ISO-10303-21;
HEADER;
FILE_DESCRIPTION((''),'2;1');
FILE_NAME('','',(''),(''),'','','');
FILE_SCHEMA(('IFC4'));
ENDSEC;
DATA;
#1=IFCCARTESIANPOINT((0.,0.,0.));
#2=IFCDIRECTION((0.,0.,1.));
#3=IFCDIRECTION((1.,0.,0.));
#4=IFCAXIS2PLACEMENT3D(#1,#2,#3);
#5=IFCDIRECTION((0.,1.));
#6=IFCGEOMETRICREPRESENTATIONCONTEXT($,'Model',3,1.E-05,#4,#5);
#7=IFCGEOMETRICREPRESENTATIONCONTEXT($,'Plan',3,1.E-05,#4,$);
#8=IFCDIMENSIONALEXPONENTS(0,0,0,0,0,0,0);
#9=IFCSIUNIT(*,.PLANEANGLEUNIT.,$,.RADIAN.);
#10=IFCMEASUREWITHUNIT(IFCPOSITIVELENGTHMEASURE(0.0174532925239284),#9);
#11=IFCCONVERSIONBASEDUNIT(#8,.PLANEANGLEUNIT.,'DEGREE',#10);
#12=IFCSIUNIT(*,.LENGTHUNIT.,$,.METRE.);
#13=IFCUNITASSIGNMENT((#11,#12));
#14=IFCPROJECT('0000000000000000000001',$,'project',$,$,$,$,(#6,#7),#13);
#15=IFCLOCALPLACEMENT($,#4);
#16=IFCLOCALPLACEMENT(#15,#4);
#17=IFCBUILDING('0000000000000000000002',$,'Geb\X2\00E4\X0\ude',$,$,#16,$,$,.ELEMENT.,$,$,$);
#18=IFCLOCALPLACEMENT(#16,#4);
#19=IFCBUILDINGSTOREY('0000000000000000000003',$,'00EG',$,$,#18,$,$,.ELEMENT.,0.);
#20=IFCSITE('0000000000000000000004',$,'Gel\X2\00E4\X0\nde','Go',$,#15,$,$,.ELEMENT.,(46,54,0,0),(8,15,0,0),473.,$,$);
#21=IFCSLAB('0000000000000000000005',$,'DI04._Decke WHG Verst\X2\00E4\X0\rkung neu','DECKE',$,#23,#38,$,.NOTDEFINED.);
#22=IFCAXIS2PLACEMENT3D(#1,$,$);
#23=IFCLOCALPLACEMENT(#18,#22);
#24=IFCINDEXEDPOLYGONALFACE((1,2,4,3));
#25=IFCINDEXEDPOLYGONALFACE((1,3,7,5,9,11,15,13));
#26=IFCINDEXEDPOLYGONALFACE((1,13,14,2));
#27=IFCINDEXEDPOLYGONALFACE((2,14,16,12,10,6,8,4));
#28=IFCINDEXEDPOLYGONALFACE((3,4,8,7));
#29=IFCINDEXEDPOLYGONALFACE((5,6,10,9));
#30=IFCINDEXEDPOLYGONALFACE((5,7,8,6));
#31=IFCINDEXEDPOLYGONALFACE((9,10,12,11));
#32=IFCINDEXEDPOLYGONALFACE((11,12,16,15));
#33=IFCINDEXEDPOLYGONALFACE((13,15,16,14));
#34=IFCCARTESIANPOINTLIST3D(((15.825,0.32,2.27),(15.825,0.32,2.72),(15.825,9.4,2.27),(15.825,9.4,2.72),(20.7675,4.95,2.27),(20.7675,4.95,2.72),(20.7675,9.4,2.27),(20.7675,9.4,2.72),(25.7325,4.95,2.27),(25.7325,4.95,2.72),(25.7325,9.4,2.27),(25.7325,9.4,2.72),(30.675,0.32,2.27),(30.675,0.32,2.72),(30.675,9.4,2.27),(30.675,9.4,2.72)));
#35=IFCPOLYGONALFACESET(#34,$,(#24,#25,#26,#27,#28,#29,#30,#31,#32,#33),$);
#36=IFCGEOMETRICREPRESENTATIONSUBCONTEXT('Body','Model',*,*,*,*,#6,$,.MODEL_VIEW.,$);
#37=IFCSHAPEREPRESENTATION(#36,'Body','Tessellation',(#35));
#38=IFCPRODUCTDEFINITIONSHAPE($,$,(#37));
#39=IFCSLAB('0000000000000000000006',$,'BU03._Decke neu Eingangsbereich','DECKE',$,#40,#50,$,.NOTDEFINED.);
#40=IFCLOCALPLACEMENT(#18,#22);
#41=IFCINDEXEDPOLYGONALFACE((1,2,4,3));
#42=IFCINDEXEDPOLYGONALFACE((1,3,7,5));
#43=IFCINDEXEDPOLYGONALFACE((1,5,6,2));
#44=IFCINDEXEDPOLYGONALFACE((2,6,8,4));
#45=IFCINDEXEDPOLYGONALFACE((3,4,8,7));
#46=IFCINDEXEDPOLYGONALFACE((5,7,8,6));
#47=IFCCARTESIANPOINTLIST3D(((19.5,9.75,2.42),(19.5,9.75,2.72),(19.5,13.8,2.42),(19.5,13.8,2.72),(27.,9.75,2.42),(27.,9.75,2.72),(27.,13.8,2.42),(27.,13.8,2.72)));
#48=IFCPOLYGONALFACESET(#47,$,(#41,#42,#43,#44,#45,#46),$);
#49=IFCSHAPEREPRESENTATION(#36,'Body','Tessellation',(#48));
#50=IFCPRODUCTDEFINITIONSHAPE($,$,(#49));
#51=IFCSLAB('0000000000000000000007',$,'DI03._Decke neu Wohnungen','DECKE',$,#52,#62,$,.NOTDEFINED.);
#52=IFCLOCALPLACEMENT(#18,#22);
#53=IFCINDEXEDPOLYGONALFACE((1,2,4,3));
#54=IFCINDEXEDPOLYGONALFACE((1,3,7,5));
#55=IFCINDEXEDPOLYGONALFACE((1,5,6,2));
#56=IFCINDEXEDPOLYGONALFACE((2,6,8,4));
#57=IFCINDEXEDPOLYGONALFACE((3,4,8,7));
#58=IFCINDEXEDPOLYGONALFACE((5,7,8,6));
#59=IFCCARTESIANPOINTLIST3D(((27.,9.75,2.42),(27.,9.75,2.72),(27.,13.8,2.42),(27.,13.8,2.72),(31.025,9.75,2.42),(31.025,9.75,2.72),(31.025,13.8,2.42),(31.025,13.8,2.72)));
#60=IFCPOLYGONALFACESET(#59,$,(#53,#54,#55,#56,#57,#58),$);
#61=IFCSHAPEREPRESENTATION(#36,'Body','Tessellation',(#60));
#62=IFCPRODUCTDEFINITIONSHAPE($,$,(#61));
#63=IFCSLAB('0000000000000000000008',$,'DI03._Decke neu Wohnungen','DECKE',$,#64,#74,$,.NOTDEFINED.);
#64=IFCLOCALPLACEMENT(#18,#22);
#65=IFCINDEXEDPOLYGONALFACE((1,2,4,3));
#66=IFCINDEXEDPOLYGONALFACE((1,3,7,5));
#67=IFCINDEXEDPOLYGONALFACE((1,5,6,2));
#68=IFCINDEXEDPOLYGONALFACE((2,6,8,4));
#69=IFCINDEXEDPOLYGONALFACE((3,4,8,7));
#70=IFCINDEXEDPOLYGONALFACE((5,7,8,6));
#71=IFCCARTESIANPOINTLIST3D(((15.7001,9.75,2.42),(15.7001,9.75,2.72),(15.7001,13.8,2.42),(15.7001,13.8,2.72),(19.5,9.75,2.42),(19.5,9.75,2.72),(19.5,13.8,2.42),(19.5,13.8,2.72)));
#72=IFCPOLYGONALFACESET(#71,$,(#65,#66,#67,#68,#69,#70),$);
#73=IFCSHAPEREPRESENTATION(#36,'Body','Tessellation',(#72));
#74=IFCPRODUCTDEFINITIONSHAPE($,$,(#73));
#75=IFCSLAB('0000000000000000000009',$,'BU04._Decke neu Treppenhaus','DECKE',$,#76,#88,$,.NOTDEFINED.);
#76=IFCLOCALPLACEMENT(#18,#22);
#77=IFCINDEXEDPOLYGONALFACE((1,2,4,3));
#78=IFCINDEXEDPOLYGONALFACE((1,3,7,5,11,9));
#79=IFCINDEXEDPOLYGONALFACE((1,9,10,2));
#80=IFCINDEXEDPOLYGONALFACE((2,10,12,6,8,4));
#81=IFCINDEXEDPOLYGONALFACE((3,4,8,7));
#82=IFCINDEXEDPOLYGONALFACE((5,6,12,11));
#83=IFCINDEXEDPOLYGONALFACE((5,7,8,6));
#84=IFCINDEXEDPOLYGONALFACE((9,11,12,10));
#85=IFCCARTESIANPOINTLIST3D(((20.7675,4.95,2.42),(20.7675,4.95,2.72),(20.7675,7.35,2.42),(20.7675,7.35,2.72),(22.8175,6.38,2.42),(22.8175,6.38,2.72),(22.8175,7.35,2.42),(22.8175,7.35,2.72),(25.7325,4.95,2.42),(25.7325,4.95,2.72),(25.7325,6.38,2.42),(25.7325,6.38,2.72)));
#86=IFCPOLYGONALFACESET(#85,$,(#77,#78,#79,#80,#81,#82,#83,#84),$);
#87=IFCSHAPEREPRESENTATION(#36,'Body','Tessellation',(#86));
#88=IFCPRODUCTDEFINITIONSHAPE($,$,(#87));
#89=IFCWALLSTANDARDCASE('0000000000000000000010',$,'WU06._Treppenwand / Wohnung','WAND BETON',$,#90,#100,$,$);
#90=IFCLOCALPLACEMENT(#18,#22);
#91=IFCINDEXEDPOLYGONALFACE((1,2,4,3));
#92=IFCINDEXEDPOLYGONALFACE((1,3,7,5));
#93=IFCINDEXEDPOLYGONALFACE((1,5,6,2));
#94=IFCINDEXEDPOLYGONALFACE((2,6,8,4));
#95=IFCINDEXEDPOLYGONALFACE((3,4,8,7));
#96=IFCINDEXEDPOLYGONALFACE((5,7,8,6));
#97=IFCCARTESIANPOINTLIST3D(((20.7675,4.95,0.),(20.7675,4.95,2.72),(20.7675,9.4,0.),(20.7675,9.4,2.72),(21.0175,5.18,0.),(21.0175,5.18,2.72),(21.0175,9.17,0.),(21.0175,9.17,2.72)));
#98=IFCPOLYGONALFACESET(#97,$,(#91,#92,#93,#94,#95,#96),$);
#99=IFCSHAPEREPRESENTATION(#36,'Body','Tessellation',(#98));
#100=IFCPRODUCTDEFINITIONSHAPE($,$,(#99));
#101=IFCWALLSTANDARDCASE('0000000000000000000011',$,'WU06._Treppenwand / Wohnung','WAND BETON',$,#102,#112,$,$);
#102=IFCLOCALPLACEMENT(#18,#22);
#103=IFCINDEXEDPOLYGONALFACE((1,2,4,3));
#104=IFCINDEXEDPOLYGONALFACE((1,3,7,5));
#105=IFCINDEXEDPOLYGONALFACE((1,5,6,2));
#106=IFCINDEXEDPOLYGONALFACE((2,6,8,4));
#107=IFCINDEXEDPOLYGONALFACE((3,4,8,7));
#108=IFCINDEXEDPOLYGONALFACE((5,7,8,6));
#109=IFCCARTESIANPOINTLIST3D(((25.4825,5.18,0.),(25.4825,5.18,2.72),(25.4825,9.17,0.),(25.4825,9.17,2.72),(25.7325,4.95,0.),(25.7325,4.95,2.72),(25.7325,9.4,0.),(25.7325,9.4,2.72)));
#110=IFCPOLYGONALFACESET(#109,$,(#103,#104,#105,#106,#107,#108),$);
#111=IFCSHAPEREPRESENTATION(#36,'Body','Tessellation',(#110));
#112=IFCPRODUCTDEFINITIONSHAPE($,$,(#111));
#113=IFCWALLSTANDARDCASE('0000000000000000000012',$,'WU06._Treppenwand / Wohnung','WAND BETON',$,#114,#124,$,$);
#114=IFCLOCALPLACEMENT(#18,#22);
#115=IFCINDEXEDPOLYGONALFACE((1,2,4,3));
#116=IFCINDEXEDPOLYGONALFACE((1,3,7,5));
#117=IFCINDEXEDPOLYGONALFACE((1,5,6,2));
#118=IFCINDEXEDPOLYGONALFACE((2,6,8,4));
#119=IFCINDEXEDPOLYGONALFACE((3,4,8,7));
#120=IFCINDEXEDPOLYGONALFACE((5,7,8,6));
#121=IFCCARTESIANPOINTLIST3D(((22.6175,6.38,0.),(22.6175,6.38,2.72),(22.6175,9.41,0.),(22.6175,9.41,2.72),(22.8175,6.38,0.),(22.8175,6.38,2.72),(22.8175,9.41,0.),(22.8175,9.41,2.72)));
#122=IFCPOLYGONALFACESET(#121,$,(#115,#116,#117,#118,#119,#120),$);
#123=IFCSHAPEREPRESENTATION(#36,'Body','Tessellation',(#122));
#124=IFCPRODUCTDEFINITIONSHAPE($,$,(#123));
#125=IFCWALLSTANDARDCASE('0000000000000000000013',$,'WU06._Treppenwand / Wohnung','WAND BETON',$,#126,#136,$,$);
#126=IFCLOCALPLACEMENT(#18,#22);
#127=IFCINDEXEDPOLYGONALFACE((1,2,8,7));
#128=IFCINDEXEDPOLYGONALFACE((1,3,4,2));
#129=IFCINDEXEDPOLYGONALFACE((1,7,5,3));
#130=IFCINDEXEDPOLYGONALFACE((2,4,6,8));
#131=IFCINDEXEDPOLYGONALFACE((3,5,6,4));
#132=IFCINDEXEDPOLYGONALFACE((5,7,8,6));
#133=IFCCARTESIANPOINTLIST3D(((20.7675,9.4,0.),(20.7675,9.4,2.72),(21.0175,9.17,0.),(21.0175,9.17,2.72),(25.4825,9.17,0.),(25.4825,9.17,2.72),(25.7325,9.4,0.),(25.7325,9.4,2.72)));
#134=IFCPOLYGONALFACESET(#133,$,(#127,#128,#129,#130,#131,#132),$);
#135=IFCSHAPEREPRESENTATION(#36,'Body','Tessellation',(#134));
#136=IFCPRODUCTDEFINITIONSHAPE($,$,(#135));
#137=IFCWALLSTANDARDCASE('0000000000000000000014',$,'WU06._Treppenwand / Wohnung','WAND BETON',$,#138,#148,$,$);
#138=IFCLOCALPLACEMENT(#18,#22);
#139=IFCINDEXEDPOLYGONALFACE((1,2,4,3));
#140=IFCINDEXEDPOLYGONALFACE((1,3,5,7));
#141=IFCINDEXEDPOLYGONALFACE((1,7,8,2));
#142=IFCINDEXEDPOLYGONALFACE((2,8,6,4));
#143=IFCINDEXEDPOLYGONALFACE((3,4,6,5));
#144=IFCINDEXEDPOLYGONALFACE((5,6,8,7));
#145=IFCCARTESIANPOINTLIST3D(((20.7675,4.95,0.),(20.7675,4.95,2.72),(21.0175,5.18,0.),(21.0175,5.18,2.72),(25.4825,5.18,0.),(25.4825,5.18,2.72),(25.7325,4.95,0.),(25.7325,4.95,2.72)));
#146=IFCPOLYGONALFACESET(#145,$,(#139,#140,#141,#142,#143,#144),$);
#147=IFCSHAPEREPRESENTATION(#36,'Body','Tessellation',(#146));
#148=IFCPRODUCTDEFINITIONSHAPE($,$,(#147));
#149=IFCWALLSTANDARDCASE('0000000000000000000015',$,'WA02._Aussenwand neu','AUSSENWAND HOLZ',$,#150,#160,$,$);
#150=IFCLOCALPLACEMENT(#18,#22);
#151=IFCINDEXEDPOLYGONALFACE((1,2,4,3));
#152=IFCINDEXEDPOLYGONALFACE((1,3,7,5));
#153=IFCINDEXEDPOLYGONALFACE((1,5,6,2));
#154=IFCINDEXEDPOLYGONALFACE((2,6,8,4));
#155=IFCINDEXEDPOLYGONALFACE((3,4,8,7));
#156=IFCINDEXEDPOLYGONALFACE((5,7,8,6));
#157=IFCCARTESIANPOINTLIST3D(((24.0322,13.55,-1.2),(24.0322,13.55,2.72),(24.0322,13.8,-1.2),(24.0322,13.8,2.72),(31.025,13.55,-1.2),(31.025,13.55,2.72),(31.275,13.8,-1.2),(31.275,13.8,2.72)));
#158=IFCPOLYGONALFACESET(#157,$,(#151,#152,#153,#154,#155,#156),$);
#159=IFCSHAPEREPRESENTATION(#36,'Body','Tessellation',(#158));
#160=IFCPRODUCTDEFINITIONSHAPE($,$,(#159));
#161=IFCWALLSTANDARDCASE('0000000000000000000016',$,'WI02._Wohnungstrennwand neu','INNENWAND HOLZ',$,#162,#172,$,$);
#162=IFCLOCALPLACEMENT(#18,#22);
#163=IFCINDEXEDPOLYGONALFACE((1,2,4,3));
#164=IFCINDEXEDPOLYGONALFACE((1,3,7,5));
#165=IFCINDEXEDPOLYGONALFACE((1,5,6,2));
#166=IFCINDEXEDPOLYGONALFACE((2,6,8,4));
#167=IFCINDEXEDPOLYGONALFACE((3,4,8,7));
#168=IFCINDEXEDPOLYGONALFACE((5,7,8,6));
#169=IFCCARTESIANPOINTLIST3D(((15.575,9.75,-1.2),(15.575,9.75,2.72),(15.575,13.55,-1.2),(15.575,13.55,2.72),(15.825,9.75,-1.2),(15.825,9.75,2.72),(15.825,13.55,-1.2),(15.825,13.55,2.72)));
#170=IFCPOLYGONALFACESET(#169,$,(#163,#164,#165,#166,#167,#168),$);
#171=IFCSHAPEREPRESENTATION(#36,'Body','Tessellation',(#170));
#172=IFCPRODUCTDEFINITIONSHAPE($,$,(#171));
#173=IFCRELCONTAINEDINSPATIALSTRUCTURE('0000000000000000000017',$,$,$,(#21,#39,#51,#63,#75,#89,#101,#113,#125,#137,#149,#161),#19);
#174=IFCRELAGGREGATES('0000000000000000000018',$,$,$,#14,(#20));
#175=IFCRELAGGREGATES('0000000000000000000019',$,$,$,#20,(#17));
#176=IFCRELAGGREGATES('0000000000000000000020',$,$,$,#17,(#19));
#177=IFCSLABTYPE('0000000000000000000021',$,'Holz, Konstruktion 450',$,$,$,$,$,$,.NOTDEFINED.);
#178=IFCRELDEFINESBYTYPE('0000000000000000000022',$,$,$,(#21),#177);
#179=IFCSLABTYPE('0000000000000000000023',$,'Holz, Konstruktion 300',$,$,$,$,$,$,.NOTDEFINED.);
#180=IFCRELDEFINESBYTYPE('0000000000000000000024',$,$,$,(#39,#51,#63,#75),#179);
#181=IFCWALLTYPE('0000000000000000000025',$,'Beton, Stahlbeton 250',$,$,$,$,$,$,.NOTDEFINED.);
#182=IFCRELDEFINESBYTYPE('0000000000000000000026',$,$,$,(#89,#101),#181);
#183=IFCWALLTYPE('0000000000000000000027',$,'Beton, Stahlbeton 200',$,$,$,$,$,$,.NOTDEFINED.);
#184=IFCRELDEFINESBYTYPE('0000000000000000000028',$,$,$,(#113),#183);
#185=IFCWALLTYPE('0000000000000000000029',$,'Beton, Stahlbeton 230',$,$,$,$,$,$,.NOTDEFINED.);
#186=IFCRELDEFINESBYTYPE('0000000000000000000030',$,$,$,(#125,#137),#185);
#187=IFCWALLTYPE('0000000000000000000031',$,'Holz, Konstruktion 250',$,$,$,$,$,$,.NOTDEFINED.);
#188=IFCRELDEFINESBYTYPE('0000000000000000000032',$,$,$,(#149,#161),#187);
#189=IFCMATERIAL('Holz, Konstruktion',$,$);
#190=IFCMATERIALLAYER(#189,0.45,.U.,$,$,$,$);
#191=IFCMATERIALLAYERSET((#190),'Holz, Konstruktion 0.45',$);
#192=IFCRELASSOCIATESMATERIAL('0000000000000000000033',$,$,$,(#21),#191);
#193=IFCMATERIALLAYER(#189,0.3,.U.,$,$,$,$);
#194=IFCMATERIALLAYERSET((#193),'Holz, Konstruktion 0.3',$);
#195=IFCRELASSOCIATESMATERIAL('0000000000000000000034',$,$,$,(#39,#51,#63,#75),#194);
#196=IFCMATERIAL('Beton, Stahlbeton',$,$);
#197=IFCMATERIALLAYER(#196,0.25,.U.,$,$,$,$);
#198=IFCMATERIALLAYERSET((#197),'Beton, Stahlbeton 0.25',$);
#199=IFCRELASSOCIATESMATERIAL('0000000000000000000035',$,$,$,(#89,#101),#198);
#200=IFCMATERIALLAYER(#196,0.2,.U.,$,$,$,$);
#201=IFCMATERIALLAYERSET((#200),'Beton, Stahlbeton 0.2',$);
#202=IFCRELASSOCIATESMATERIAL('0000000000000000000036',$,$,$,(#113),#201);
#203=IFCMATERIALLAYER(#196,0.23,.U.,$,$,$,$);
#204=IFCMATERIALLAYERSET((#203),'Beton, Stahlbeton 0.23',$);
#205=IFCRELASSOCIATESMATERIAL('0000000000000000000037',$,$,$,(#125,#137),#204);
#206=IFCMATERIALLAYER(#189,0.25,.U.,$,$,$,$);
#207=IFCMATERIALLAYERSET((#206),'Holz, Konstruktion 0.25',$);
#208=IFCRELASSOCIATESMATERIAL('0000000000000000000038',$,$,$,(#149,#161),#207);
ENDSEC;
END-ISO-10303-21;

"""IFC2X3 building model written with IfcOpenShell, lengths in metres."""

from ifc_helpers import new_model, entity, si_unit, converted_unit, direction, frame, origin_with_axes, place, context, subcontext, project, spatial, polyline, outline, extrude, material, layer, layer_set, layer_usage, type_object, element, save


model = new_model("IFC2X3")

# Units and contexts
model_context = context("Model", 3, precision=1e-05, world=origin_with_axes(), true_north=direction((0.0, 1.0)))
plan_context = context("Plan", 3, precision=1e-05, world=origin_with_axes())
body_context = subcontext(model_context, "Body", "Model", "MODEL_VIEW")
ifc_project = project(units=[converted_unit("PLANEANGLEUNIT", "DEGREE", entity("IfcPositiveLengthMeasure", 0.0174532925239284), si_unit("PLANEANGLEUNIT", "RADIAN"), dimensions=[0, 0, 0, 0, 0, 0, 0]), si_unit("LENGTHUNIT", "METRE")], contexts=[model_context, plan_context])

# Site, building, storey
site_placement = place(None, origin_with_axes())
site = spatial("IfcSite", under=ifc_project, at=site_placement, Name="Gelände", Description="Go", CompositionType="ELEMENT", RefLatitude=(46, 54, 0, 0), RefLongitude=(8, 15, 0, 0), RefElevation=473.0)
building_placement = place(site_placement, origin_with_axes())
building = spatial("IfcBuilding", under=site, at=building_placement, Name="Gebäude", CompositionType="ELEMENT")
storey_placement = place(building_placement, origin_with_axes())
storey = spatial("IfcBuildingStorey", under=building, at=storey_placement, Name="00EG", CompositionType="ELEMENT", Elevation=0.0)

# Slabs
ifc_material_1 = material(Name="Holz, Konstruktion")
ifc_layer_1 = layer(ifc_material_1, 0.45, ventilated="UNKNOWN")
ifc_layer_set_1 = layer_set([ifc_layer_1], Name="Holz, Konstruktion 0.45")
ifc_layer_usage_1 = layer_usage(ifc_layer_set_1, "AXIS3", "NEGATIVE", 0.45)
slab_type_1 = type_object("IfcSlabType", Name="Holz, Konstruktion 450", PredefinedType="NOTDEFINED")
slab_1_placement = place(storey_placement, frame((15.825, 9.4, 2.72), z_axis=(0.0, 0.0, 1.0), x_axis=(1.0, 0.0, 0.0)))
element("IfcSlab", 1, at=slab_1_placement, inside=storey, type_object=slab_type_1, material=ifc_layer_usage_1, Name="DI04._Decke WHG Verstärkung neu", Description="DECKE", PredefinedType="NOTDEFINED", context=body_context, shape_type="SweptSolid", body=[
    extrude(outline(polyline([(0.0, 0.0), (0.0, -9.08), (14.85, -9.08), (14.85, 0.0), (9.9075, 0.0), (9.9075, -4.45), (4.9425, -4.45), (4.9425, 0.0), (0.0, 0.0)])), frame((0.0, 0.0, -0.45), z_axis=(0.0, 0.0, 1.0), x_axis=(1.0, 0.0, 0.0)), (0.0, 0.0, 1.0), 0.45),
])
ifc_layer_2 = layer(ifc_material_1, 0.3, ventilated="UNKNOWN")
ifc_layer_set_2 = layer_set([ifc_layer_2], Name="Holz, Konstruktion 0.3")
ifc_layer_usage_2 = layer_usage(ifc_layer_set_2, "AXIS3", "NEGATIVE", 0.3)
slab_type_2 = type_object("IfcSlabType", Name="Holz, Konstruktion 300", PredefinedType="NOTDEFINED")
slab_2_placement = place(storey_placement, frame((19.5, 9.75, 2.72), z_axis=(0.0, 0.0, 1.0), x_axis=(1.0, 0.0, 0.0)))
element("IfcSlab", 2, at=slab_2_placement, inside=storey, type_object=slab_type_2, material=ifc_layer_usage_2, Name="BU03._Decke neu Eingangsbereich", Description="DECKE", PredefinedType="NOTDEFINED", context=body_context, shape_type="SweptSolid", body=[
    extrude(outline(polyline([(0.0, 0.0), (7.5, 0.0), (7.5, 4.05), (0.0, 4.05), (0.0, 0.0)])), frame((0.0, 0.0, -0.3), z_axis=(0.0, 0.0, 1.0), x_axis=(1.0, 0.0, 0.0)), (0.0, 0.0, 1.0), 0.3),
])
ifc_layer_usage_3 = layer_usage(ifc_layer_set_2, "AXIS3", "NEGATIVE", 0.3)
slab_3_placement = place(storey_placement, frame((27.0, 9.75, 2.72), z_axis=(0.0, 0.0, 1.0), x_axis=(1.0, 0.0, 0.0)))
element("IfcSlab", 3, at=slab_3_placement, inside=storey, type_object=slab_type_2, material=ifc_layer_usage_3, Name="DI03._Decke neu Wohnungen", Description="DECKE", PredefinedType="NOTDEFINED", context=body_context, shape_type="SweptSolid", body=[
    extrude(outline(polyline([(0.0, 0.0), (4.025, 0.0), (4.025, 4.05), (0.0, 4.05), (0.0, 0.0)])), frame((0.0, 0.0, -0.3), z_axis=(0.0, 0.0, 1.0), x_axis=(1.0, 0.0, 0.0)), (0.0, 0.0, 1.0), 0.3),
])
ifc_layer_usage_4 = layer_usage(ifc_layer_set_2, "AXIS3", "NEGATIVE", 0.3)
slab_4_placement = place(storey_placement, frame((15.7001, 9.75, 2.72), z_axis=(0.0, 0.0, 1.0), x_axis=(1.0, 0.0, 0.0)))
element("IfcSlab", 4, at=slab_4_placement, inside=storey, type_object=slab_type_2, material=ifc_layer_usage_4, Name="DI03._Decke neu Wohnungen", Description="DECKE", PredefinedType="NOTDEFINED", context=body_context, shape_type="SweptSolid", body=[
    extrude(outline(polyline([(0.0, 0.0), (3.7999, 0.0), (3.7999, 4.05), (0.0, 4.05), (0.0, 0.0)])), frame((0.0, 0.0, -0.3), z_axis=(0.0, 0.0, 1.0), x_axis=(1.0, 0.0, 0.0)), (0.0, 0.0, 1.0), 0.3),
])
ifc_layer_usage_5 = layer_usage(ifc_layer_set_2, "AXIS3", "NEGATIVE", 0.3)
slab_5_placement = place(storey_placement, frame((20.7675, 7.35, 2.72), z_axis=(0.0, 0.0, 1.0), x_axis=(1.0, 0.0, 0.0)))
element("IfcSlab", 5, at=slab_5_placement, inside=storey, type_object=slab_type_2, material=ifc_layer_usage_5, Name="BU04._Decke neu Treppenhaus", Description="DECKE", PredefinedType="NOTDEFINED", context=body_context, shape_type="SweptSolid", body=[
    extrude(outline(polyline([(0.0, 0.0), (0.0, -2.4), (4.965, -2.4), (4.965, -0.97), (2.05, -0.97), (2.05, 0.0), (0.0, 0.0)])), frame((0.0, 0.0, -0.3), z_axis=(0.0, 0.0, 1.0), x_axis=(1.0, 0.0, 0.0)), (0.0, 0.0, 1.0), 0.3),
])

# Walls
ifc_material_2 = material(Name="Beton, Stahlbeton")
ifc_layer_3 = layer(ifc_material_2, 0.25, ventilated="UNKNOWN")
ifc_layer_set_3 = layer_set([ifc_layer_3], Name="Beton, Stahlbeton 0.25")
ifc_layer_usage_6 = layer_usage(ifc_layer_set_3, "AXIS2", "NEGATIVE", 0.25)
wall_type_1 = type_object("IfcWallType", Name="Beton, Stahlbeton 250", PredefinedType="NOTDEFINED")
wall_1_placement = place(storey_placement, frame((21.0175, 5.18, 0.0), z_axis=(0.0, 0.0, 1.0), x_axis=(0.0, 1.0, 0.0)))
element("IfcWallStandardCase", 6, at=wall_1_placement, inside=storey, type_object=wall_type_1, material=ifc_layer_usage_6, Name="WU06._Treppenwand / Wohnung", Description="WAND BETON", context=body_context, shape_type="SweptSolid", body=[
    extrude(outline(polyline([(0.0, 0.0), (3.99, 0.0), (4.22, 0.25), (-0.23, 0.25), (0.0, 0.0)])), origin_with_axes(), (0.0, 0.0, 1.0), 2.72),
])
ifc_layer_usage_7 = layer_usage(ifc_layer_set_3, "AXIS2", "NEGATIVE", 0.25)
wall_2_placement = place(storey_placement, frame((25.4825, 9.17, 0.0), z_axis=(0.0, 0.0, 1.0), x_axis=(0.0, -1.0, 0.0)))
element("IfcWallStandardCase", 7, at=wall_2_placement, inside=storey, type_object=wall_type_1, material=ifc_layer_usage_7, Name="WU06._Treppenwand / Wohnung", Description="WAND BETON", context=body_context, shape_type="SweptSolid", body=[
    extrude(outline(polyline([(0.0, 0.0), (3.99, 0.0), (4.22, 0.25), (-0.23, 0.25), (0.0, 0.0)])), origin_with_axes(), (0.0, 0.0, 1.0), 2.72),
])
ifc_layer_4 = layer(ifc_material_2, 0.2, ventilated="UNKNOWN")
ifc_layer_set_4 = layer_set([ifc_layer_4], Name="Beton, Stahlbeton 0.2")
ifc_layer_usage_8 = layer_usage(ifc_layer_set_4, "AXIS2", "POSITIVE", -0.2)
wall_type_2 = type_object("IfcWallType", Name="Beton, Stahlbeton 200", PredefinedType="NOTDEFINED")
wall_3_placement = place(storey_placement, frame((22.6175, 6.38, 0.0), z_axis=(0.0, 0.0, 1.0), x_axis=(0.0, 1.0, 0.0)))
element("IfcWallStandardCase", 8, at=wall_3_placement, inside=storey, type_object=wall_type_2, material=ifc_layer_usage_8, Name="WU06._Treppenwand / Wohnung", Description="WAND BETON", context=body_context, shape_type="SweptSolid", body=[
    extrude(outline(polyline([(0.0, -0.2), (3.03, -0.2), (3.03, 0.0), (0.0, 0.0), (0.0, -0.2)])), origin_with_axes(), (0.0, 0.0, 1.0), 2.72),
])
ifc_layer_5 = layer(ifc_material_2, 0.23, ventilated="UNKNOWN")
ifc_layer_set_5 = layer_set([ifc_layer_5], Name="Beton, Stahlbeton 0.23")
ifc_layer_usage_9 = layer_usage(ifc_layer_set_5, "AXIS2", "NEGATIVE", 0.23)
wall_type_3 = type_object("IfcWallType", Name="Beton, Stahlbeton 230", PredefinedType="NOTDEFINED")
wall_4_placement = place(storey_placement, frame((21.0175, 9.17, 0.0), z_axis=(0.0, 0.0, 1.0), x_axis=(1.0, 0.0, 0.0)))
element("IfcWallStandardCase", 9, at=wall_4_placement, inside=storey, type_object=wall_type_3, material=ifc_layer_usage_9, Name="WU06._Treppenwand / Wohnung", Description="WAND BETON", context=body_context, shape_type="SweptSolid", body=[
    extrude(outline(polyline([(0.0, 0.0), (4.465, 0.0), (4.715, 0.23), (-0.25, 0.23), (0.0, 0.0)])), origin_with_axes(), (0.0, 0.0, 1.0), 2.72),
])
ifc_layer_usage_10 = layer_usage(ifc_layer_set_5, "AXIS2", "NEGATIVE", 0.23)
wall_5_placement = place(storey_placement, frame((25.4825, 5.18, 0.0), z_axis=(0.0, 0.0, 1.0), x_axis=(-1.0, 0.0, 0.0)))
element("IfcWallStandardCase", 10, at=wall_5_placement, inside=storey, type_object=wall_type_3, material=ifc_layer_usage_10, Name="WU06._Treppenwand / Wohnung", Description="WAND BETON", context=body_context, shape_type="SweptSolid", body=[
    extrude(outline(polyline([(0.0, 0.0), (4.465, 0.0), (4.715, 0.23), (-0.25, 0.23), (0.0, 0.0)])), origin_with_axes(), (0.0, 0.0, 1.0), 2.72),
])
ifc_layer_6 = layer(ifc_material_1, 0.25, ventilated="UNKNOWN")
ifc_layer_set_6 = layer_set([ifc_layer_6], Name="Holz, Konstruktion 0.25")
ifc_layer_usage_11 = layer_usage(ifc_layer_set_6, "AXIS2", "POSITIVE", 0.0)
wall_type_4 = type_object("IfcWallType", Name="Holz, Konstruktion 250", PredefinedType="NOTDEFINED")
wall_6_placement = place(storey_placement, frame((31.275, 13.8, -1.2), z_axis=(0.0, 0.0, 1.0), x_axis=(-1.0, 0.0, 0.0)))
element("IfcWallStandardCase", 11, at=wall_6_placement, inside=storey, type_object=wall_type_4, material=ifc_layer_usage_11, Name="WA02._Aussenwand neu", Description="AUSSENWAND HOLZ", context=body_context, shape_type="SweptSolid", body=[
    extrude(outline(polyline([(0.0, 0.0), (7.2428, 0.0), (7.2428, 0.25), (0.25, 0.25), (0.0, 0.0)])), origin_with_axes(), (0.0, 0.0, 1.0), 3.92),
])
ifc_layer_usage_12 = layer_usage(ifc_layer_set_6, "AXIS2", "NEGATIVE", 0.0)
wall_7_placement = place(storey_placement, frame((15.825, 13.55, -1.2), z_axis=(0.0, 0.0, 1.0), x_axis=(0.0, -1.0, 0.0)))
element("IfcWallStandardCase", 12, at=wall_7_placement, inside=storey, type_object=wall_type_4, material=ifc_layer_usage_12, Name="WI02._Wohnungstrennwand neu", Description="INNENWAND HOLZ", context=body_context, shape_type="SweptSolid", body=[
    extrude(outline(polyline([(0.0, -0.25), (3.8, -0.25), (3.8, 0.0), (0.0, 0.0), (0.0, -0.25)])), origin_with_axes(), (0.0, 0.0, 1.0), 3.92),
])

save(model, "model.ifc")
